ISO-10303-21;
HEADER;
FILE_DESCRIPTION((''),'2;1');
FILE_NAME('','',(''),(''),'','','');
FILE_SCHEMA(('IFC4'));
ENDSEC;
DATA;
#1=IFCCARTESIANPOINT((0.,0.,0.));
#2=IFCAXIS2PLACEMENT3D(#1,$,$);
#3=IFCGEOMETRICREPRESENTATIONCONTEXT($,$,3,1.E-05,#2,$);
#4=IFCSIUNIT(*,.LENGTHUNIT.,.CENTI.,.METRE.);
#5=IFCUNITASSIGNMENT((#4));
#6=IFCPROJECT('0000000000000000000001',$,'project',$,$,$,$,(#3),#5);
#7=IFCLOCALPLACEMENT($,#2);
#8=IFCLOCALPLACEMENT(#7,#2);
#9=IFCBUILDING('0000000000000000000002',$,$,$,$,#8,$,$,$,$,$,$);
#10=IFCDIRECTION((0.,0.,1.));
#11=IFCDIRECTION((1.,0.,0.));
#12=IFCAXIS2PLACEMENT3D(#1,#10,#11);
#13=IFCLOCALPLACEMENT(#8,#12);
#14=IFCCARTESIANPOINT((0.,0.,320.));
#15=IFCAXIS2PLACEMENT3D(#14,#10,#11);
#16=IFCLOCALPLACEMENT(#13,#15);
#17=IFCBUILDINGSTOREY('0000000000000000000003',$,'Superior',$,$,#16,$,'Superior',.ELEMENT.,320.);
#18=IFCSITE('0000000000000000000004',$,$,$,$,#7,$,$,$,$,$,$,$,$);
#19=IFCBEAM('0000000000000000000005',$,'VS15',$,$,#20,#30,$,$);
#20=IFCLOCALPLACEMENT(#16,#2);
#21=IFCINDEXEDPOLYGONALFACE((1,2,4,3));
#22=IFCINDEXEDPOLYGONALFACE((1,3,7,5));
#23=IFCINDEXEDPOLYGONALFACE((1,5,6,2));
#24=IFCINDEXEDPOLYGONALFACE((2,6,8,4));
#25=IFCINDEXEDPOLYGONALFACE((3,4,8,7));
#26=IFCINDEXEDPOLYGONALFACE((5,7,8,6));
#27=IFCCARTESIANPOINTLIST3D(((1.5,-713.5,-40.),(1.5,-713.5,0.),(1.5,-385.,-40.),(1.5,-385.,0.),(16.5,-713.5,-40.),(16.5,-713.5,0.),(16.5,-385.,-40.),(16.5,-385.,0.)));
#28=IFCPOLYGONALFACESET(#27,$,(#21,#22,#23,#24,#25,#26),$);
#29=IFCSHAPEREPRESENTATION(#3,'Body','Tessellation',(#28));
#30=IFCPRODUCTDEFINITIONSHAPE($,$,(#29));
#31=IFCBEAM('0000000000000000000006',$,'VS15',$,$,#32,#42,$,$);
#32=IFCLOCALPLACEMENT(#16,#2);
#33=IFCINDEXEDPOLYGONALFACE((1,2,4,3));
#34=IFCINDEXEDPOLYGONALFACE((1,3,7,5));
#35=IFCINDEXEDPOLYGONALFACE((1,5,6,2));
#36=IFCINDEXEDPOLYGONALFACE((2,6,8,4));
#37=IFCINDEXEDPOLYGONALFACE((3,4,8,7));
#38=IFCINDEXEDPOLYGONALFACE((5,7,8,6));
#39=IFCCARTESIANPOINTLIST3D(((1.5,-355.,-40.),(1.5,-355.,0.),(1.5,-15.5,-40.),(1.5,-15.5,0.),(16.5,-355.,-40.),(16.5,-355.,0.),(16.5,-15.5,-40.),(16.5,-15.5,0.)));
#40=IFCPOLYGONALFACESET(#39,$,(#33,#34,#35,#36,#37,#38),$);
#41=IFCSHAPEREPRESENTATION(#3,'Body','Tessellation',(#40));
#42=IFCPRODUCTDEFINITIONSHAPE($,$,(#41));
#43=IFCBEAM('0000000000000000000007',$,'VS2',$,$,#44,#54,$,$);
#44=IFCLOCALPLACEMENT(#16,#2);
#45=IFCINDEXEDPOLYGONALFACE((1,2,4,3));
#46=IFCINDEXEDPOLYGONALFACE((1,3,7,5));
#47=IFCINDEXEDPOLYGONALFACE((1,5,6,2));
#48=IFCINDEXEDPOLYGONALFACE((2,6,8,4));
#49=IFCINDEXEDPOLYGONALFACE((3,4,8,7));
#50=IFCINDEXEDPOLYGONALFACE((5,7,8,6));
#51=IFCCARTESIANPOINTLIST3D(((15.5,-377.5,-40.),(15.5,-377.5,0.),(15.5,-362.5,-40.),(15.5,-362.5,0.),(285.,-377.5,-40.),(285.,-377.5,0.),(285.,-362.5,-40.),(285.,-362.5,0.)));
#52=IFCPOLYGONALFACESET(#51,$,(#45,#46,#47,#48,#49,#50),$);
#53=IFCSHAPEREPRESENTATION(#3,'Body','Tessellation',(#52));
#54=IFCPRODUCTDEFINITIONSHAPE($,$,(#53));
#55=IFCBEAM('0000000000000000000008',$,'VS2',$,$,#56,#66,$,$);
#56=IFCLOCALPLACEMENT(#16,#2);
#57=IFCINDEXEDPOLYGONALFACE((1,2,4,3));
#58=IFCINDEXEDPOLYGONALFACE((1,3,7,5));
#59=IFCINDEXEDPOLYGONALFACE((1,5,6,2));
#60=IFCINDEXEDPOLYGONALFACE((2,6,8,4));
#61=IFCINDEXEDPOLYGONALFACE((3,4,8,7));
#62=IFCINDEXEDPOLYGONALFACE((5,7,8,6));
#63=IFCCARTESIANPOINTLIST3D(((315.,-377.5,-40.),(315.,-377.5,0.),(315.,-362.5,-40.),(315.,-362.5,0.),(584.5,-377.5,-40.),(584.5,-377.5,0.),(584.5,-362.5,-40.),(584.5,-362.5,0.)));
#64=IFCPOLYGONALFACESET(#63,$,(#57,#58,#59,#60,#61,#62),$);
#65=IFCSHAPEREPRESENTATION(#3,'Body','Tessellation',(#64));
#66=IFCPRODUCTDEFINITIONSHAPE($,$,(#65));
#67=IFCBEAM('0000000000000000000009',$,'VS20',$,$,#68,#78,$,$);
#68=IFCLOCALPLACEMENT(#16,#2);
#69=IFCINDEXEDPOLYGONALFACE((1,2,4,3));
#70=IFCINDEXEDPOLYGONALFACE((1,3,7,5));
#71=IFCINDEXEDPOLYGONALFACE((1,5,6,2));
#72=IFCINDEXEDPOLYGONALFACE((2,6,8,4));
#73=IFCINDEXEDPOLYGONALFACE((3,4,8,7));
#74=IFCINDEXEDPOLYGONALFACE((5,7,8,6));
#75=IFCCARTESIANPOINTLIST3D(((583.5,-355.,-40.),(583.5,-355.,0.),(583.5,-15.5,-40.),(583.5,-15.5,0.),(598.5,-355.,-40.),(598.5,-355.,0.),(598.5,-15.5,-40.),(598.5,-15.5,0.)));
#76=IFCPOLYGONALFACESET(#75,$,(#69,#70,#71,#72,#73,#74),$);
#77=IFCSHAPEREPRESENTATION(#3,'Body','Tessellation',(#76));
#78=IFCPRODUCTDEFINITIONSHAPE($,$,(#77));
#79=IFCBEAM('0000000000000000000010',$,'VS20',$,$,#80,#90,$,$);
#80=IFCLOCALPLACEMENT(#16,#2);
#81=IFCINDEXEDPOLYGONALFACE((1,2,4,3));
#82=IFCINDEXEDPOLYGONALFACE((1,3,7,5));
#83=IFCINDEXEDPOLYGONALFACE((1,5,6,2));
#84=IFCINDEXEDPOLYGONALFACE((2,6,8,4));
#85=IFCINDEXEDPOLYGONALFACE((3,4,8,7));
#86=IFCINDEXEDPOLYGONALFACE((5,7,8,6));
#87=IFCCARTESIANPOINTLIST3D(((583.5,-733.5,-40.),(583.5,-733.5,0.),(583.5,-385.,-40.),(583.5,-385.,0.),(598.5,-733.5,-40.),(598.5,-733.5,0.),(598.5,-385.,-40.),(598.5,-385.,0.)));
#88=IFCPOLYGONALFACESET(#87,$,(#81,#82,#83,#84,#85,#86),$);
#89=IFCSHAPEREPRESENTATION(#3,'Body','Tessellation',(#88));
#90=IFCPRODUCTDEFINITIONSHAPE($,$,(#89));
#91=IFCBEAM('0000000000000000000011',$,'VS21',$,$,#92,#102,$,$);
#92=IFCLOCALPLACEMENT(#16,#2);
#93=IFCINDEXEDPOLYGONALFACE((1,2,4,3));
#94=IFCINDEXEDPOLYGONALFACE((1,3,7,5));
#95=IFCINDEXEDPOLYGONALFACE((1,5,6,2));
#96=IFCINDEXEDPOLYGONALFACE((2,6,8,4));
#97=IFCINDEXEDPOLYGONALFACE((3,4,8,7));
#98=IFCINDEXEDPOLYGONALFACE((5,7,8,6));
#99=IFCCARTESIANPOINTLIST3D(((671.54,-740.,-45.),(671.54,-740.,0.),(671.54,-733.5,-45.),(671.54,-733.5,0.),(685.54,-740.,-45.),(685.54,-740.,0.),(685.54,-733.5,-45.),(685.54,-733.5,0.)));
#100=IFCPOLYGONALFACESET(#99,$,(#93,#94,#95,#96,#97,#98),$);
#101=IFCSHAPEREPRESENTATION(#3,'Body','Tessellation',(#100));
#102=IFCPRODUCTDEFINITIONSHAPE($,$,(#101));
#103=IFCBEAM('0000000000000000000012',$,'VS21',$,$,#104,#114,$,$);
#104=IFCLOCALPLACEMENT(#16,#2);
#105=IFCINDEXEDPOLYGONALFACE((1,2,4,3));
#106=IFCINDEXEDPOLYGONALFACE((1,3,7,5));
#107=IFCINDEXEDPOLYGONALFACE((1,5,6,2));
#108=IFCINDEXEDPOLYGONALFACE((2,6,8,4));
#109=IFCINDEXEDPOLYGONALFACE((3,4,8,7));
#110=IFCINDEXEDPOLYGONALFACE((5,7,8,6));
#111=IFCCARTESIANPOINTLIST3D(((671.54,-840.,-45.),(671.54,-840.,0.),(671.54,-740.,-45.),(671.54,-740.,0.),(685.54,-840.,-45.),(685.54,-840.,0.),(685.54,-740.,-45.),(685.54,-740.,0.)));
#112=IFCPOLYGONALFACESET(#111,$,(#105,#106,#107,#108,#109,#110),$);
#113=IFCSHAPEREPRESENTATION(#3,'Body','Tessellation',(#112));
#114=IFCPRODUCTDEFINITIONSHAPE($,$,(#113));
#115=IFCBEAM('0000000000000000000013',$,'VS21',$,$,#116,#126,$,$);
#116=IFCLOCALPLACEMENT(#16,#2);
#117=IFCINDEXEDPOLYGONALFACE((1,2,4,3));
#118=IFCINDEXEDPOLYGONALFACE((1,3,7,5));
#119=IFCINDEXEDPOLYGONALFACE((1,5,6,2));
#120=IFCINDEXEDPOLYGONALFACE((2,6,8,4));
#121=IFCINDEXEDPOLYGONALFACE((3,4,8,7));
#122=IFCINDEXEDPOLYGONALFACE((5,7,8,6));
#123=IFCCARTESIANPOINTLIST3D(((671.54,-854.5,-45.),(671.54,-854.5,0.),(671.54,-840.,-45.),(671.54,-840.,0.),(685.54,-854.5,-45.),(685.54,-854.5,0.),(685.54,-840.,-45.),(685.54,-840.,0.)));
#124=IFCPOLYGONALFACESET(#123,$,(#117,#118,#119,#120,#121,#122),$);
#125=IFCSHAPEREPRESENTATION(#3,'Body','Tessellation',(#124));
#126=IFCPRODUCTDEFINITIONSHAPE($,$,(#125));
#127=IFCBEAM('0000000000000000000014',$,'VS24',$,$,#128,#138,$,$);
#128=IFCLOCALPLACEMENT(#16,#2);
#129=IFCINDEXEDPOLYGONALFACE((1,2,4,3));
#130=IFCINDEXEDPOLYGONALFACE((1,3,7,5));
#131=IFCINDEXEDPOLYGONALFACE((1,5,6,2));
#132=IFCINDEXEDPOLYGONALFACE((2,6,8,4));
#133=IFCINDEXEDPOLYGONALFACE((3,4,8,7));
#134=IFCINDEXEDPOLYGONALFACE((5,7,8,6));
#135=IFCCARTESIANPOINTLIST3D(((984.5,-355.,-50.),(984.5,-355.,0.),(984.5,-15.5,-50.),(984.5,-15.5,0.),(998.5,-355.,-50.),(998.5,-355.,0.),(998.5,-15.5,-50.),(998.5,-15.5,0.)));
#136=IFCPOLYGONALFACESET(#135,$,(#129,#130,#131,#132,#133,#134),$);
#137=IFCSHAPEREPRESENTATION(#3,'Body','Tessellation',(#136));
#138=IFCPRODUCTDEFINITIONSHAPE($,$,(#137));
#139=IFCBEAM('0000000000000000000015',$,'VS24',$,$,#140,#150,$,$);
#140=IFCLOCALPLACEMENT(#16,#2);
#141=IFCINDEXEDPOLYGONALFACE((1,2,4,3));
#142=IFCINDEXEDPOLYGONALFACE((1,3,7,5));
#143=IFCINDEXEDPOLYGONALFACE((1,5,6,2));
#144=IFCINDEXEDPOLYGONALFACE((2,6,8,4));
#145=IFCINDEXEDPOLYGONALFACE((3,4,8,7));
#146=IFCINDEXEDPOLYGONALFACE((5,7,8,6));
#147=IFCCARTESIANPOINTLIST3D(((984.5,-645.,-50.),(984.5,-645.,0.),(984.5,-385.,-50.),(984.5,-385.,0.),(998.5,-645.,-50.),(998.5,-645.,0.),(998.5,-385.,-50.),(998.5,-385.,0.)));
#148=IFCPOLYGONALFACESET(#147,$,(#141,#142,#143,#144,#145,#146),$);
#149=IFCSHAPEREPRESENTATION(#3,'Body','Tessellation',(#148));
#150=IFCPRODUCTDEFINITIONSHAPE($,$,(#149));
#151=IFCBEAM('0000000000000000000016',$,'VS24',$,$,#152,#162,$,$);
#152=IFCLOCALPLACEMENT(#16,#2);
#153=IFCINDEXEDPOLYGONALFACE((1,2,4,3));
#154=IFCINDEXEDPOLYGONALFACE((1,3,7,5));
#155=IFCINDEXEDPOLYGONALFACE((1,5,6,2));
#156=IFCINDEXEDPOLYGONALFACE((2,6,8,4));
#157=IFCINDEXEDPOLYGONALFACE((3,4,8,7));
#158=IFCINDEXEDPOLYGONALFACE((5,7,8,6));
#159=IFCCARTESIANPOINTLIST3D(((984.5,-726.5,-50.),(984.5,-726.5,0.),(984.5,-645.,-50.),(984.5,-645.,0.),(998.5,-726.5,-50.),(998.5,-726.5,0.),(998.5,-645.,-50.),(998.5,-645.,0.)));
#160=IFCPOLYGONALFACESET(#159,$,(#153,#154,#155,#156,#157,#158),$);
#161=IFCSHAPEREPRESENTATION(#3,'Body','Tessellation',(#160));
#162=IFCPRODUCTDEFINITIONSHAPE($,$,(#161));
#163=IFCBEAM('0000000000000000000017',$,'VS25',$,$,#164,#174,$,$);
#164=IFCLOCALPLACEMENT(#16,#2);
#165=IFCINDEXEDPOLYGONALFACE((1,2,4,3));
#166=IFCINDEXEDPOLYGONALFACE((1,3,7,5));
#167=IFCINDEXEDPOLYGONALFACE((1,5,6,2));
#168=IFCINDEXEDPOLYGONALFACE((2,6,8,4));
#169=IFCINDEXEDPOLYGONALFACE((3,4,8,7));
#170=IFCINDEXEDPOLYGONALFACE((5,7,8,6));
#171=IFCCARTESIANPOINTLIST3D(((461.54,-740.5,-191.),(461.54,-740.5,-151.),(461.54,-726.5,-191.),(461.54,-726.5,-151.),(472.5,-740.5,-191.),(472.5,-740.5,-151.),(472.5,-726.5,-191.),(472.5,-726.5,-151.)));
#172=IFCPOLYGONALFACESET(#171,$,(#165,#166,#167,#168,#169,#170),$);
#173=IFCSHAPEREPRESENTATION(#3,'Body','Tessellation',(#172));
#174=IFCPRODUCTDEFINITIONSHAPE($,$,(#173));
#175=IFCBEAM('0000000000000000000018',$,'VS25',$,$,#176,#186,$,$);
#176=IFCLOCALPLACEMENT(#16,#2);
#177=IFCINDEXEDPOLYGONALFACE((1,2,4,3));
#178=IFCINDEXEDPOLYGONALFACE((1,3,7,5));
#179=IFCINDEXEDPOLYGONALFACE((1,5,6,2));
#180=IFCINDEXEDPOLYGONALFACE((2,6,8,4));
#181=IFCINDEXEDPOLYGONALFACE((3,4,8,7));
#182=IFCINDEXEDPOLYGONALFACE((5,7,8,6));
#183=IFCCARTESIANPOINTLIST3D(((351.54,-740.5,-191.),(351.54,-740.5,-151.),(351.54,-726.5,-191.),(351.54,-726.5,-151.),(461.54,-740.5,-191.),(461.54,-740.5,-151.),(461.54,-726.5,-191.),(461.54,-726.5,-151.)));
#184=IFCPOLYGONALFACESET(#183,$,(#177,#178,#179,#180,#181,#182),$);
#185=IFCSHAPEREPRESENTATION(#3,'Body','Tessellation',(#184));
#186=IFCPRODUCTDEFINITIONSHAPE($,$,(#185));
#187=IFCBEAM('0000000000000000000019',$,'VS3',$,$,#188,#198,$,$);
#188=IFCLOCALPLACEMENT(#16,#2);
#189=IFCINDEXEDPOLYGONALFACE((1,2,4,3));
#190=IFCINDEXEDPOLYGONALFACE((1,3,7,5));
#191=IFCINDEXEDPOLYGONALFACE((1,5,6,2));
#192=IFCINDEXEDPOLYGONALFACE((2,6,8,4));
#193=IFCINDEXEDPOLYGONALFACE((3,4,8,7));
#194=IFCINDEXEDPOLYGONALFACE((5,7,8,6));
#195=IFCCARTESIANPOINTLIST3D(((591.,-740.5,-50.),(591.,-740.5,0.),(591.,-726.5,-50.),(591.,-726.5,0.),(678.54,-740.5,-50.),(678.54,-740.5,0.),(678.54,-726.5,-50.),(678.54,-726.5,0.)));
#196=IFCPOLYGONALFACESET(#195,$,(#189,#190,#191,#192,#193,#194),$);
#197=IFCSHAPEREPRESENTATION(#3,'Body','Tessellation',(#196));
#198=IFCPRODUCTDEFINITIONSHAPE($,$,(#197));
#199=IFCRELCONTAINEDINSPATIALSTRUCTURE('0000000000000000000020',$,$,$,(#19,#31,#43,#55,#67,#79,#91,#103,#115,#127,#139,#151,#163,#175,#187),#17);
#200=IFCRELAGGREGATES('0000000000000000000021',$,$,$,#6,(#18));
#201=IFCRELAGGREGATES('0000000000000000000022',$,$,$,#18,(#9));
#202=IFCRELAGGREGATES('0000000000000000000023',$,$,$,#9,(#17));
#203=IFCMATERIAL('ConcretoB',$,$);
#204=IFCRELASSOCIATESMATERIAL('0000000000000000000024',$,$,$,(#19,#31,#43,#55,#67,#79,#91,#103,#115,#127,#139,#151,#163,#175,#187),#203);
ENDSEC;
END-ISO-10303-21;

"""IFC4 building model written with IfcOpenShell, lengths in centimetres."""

from ifc_helpers import new_model, si_unit, frame, origin, origin_with_axes, place, context, project, spatial, polyline, outline, extrude, material, element, save


model = new_model("IFC4")

# Units and contexts
context_of_model = context(None, 3, precision=1e-05, world=origin())
ifc_project = project(units=[si_unit("LENGTHUNIT", "METRE", prefix="CENTI")], contexts=[context_of_model])

# Site, building, storey
site_placement = place(None, origin())
site = spatial("IfcSite", under=ifc_project, at=site_placement)
building_placement = place(site_placement, origin())
building = spatial("IfcBuilding", under=site, at=building_placement)
placement = place(building_placement, origin_with_axes())
storey_placement = place(placement, frame((0.0, 0.0, 320.0), z_axis=(0.0, 0.0, 1.0), x_axis=(1.0, 0.0, 0.0)))
storey = spatial("IfcBuildingStorey", under=building, at=storey_placement, Name="Superior", LongName="Superior", CompositionType="ELEMENT", Elevation=320.0)

# Shared definitions
ifc_material = material(Name="ConcretoB")

# Beams
beam_1_placement = place(storey_placement, frame((9.0, -549.25, 0.0), z_axis=(0.0, 0.0, 1.0), x_axis=(1.0, 0.0, 0.0)))
element("IfcBeam", 1, at=beam_1_placement, inside=storey, material=ifc_material, Name="VS15", context=context_of_model, shape_type="SolidModel", body=[
    extrude(outline(polyline([(-7.5, -20.0), (7.5, -20.0), (7.5, 20.0), (-7.5, 20.0), (-7.5, -20.0)])), frame((0.0, -164.25, -20.0), z_axis=(0.0, 1.0, 0.0), x_axis=(1.0, 0.0, 0.0)), (0.0, 0.0, 1.0), 328.5),
])
beam_2_placement = place(storey_placement, frame((9.0, -185.25, 0.0), z_axis=(0.0, 0.0, 1.0), x_axis=(1.0, 0.0, 0.0)))
element("IfcBeam", 2, at=beam_2_placement, inside=storey, material=ifc_material, Name="VS15", context=context_of_model, shape_type="SolidModel", body=[
    extrude(outline(polyline([(-7.5, -20.0), (7.5, -20.0), (7.5, 20.0), (-7.5, 20.0), (-7.5, -20.0)])), frame((0.0, -169.75, -20.0), z_axis=(0.0, 1.0, 0.0), x_axis=(1.0, 0.0, 0.0)), (0.0, 0.0, 1.0), 339.5),
])
for number, where, z_axis, x_axis, name in (
    (3, (150.25, -370.0, 0.0), (0.0, 0.0, 1.0), (1.0, 0.0, 0.0), "VS2"),
    (4, (449.75, -370.0, 0.0), (0.0, 0.0, 1.0), (1.0, 0.0, 0.0), "VS2"),
):
    element("IfcBeam", number, at=place(storey_placement, frame(where, z_axis=z_axis, x_axis=x_axis)), inside=storey, material=ifc_material, Name=name, context=context_of_model, shape_type="SolidModel", body=[
        extrude(outline(polyline([(-7.5, -20.0), (7.5, -20.0), (7.5, 20.0), (-7.5, 20.0), (-7.5, -20.0)])), frame((-134.75, 0.0, -20.0), z_axis=(1.0, 0.0, 0.0), x_axis=(0.0, -1.0, 0.0)), (0.0, 0.0, 1.0), 269.5),
    ])
beam_3_placement = place(storey_placement, frame((591.0, -185.25, 0.0), z_axis=(0.0, 0.0, 1.0), x_axis=(1.0, 0.0, 0.0)))
element("IfcBeam", 5, at=beam_3_placement, inside=storey, material=ifc_material, Name="VS20", context=context_of_model, shape_type="SolidModel", body=[
    extrude(outline(polyline([(-7.5, -20.0), (7.5, -20.0), (7.5, 20.0), (-7.5, 20.0), (-7.5, -20.0)])), frame((0.0, -169.75, -20.0), z_axis=(0.0, 1.0, 0.0), x_axis=(1.0, 0.0, 0.0)), (0.0, 0.0, 1.0), 339.5),
])
beam_4_placement = place(storey_placement, frame((591.0, -559.25, 0.0), z_axis=(0.0, 0.0, 1.0), x_axis=(1.0, 0.0, 0.0)))
element("IfcBeam", 6, at=beam_4_placement, inside=storey, material=ifc_material, Name="VS20", context=context_of_model, shape_type="SolidModel", body=[
    extrude(outline(polyline([(-7.5, -20.0), (7.5, -20.0), (7.5, 20.0), (-7.5, 20.0), (-7.5, -20.0)])), frame((0.0, -174.25, -20.0), z_axis=(0.0, 1.0, 0.0), x_axis=(1.0, 0.0, 0.0)), (0.0, 0.0, 1.0), 348.5),
])
beam_5_placement = place(storey_placement, frame((678.54, -736.75, 0.0), z_axis=(0.0, 0.0, 1.0), x_axis=(1.0, 0.0, 0.0)))
element("IfcBeam", 7, at=beam_5_placement, inside=storey, material=ifc_material, Name="VS21", context=context_of_model, shape_type="SolidModel", body=[
    extrude(outline(polyline([(-7.0, -22.5), (7.0, -22.5), (7.0, 22.5), (-7.0, 22.5), (-7.0, -22.5)])), frame((0.0, -3.25, -22.5), z_axis=(0.0, 1.0, 0.0), x_axis=(1.0, 0.0, 0.0)), (0.0, 0.0, 1.0), 6.5),
])
beam_6_placement = place(storey_placement, frame((678.54, -790.0, 0.0), z_axis=(0.0, 0.0, 1.0), x_axis=(1.0, 0.0, 0.0)))
element("IfcBeam", 8, at=beam_6_placement, inside=storey, material=ifc_material, Name="VS21", context=context_of_model, shape_type="SolidModel", body=[
    extrude(outline(polyline([(-7.0, -22.5), (7.0, -22.5), (7.0, 22.5), (-7.0, 22.5), (-7.0, -22.5)])), frame((0.0, -50.0, -22.5), z_axis=(0.0, 1.0, 0.0), x_axis=(1.0, 0.0, 0.0)), (0.0, 0.0, 1.0), 100.0),
])
beam_7_placement = place(storey_placement, frame((678.54, -847.25, 0.0), z_axis=(0.0, 0.0, 1.0), x_axis=(1.0, 0.0, 0.0)))
element("IfcBeam", 9, at=beam_7_placement, inside=storey, material=ifc_material, Name="VS21", context=context_of_model, shape_type="SolidModel", body=[
    extrude(outline(polyline([(-7.0, -22.5), (7.0, -22.5), (7.0, 22.5), (-7.0, 22.5), (-7.0, -22.5)])), frame((0.0, -7.25, -22.5), z_axis=(0.0, 1.0, 0.0), x_axis=(1.0, 0.0, 0.0)), (0.0, 0.0, 1.0), 14.5),
])
beam_8_placement = place(storey_placement, frame((991.5, -185.25, 0.0), z_axis=(0.0, 0.0, 1.0), x_axis=(1.0, 0.0, 0.0)))
element("IfcBeam", 10, at=beam_8_placement, inside=storey, material=ifc_material, Name="VS24", context=context_of_model, shape_type="SolidModel", body=[
    extrude(outline(polyline([(-7.0, -25.0), (7.0, -25.0), (7.0, 25.0), (-7.0, 25.0), (-7.0, -25.0)])), frame((0.0, -169.75, -25.0), z_axis=(0.0, 1.0, 0.0), x_axis=(1.0, 0.0, 0.0)), (0.0, 0.0, 1.0), 339.5),
])
beam_9_placement = place(storey_placement, frame((991.5, -515.0, 0.0), z_axis=(0.0, 0.0, 1.0), x_axis=(1.0, 0.0, 0.0)))
element("IfcBeam", 11, at=beam_9_placement, inside=storey, material=ifc_material, Name="VS24", context=context_of_model, shape_type="SolidModel", body=[
    extrude(outline(polyline([(-7.0, -25.0), (7.0, -25.0), (7.0, 25.0), (-7.0, 25.0), (-7.0, -25.0)])), frame((0.0, -130.0, -25.0), z_axis=(0.0, 1.0, 0.0), x_axis=(1.0, 0.0, 0.0)), (0.0, 0.0, 1.0), 260.0),
])
beam_10_placement = place(storey_placement, frame((991.5, -685.75, 0.0), z_axis=(0.0, 0.0, 1.0), x_axis=(1.0, 0.0, 0.0)))
element("IfcBeam", 12, at=beam_10_placement, inside=storey, material=ifc_material, Name="VS24", context=context_of_model, shape_type="SolidModel", body=[
    extrude(outline(polyline([(-7.0, -25.0), (7.0, -25.0), (7.0, 25.0), (-7.0, 25.0), (-7.0, -25.0)])), frame((0.0, -40.75, -25.0), z_axis=(0.0, 1.0, 0.0), x_axis=(1.0, 0.0, 0.0)), (0.0, 0.0, 1.0), 81.5),
])
beam_11_placement = place(storey_placement, frame((467.02, -733.5, -151.0), z_axis=(0.0, 0.0, 1.0), x_axis=(1.0, 0.0, 0.0)))
element("IfcBeam", 13, at=beam_11_placement, inside=storey, material=ifc_material, Name="VS25", context=context_of_model, shape_type="SolidModel", body=[
    extrude(outline(polyline([(-7.0, -20.0), (7.0, -20.0), (7.0, 20.0), (-7.0, 20.0), (-7.0, -20.0)])), frame((-5.48, 0.0, -20.0), z_axis=(1.0, 0.0, 0.0), x_axis=(0.0, -1.0, 0.0)), (0.0, 0.0, 1.0), 10.96),
])
beam_12_placement = place(storey_placement, frame((406.54, -733.5, -151.0), z_axis=(0.0, 0.0, 1.0), x_axis=(1.0, 0.0, 0.0)))
element("IfcBeam", 14, at=beam_12_placement, inside=storey, material=ifc_material, Name="VS25", context=context_of_model, shape_type="SolidModel", body=[
    extrude(outline(polyline([(-7.0, -20.0), (7.0, -20.0), (7.0, 20.0), (-7.0, 20.0), (-7.0, -20.0)])), frame((-55.0, 0.0, -20.0), z_axis=(1.0, 0.0, 0.0), x_axis=(0.0, -1.0, 0.0)), (0.0, 0.0, 1.0), 110.0),
])
beam_13_placement = place(storey_placement, frame((634.77, -733.5, 0.0), z_axis=(0.0, 0.0, 1.0), x_axis=(1.0, 0.0, 0.0)))
element("IfcBeam", 15, at=beam_13_placement, inside=storey, material=ifc_material, Name="VS3", context=context_of_model, shape_type="SolidModel", body=[
    extrude(outline(polyline([(-7.0, -25.0), (7.0, -25.0), (7.0, 25.0), (-7.0, 25.0), (-7.0, -25.0)])), frame((-43.77, 0.0, -25.0), z_axis=(1.0, 0.0, 0.0), x_axis=(0.0, -1.0, 0.0)), (0.0, 0.0, 1.0), 87.54),
])

save(model, "model.ifc")
